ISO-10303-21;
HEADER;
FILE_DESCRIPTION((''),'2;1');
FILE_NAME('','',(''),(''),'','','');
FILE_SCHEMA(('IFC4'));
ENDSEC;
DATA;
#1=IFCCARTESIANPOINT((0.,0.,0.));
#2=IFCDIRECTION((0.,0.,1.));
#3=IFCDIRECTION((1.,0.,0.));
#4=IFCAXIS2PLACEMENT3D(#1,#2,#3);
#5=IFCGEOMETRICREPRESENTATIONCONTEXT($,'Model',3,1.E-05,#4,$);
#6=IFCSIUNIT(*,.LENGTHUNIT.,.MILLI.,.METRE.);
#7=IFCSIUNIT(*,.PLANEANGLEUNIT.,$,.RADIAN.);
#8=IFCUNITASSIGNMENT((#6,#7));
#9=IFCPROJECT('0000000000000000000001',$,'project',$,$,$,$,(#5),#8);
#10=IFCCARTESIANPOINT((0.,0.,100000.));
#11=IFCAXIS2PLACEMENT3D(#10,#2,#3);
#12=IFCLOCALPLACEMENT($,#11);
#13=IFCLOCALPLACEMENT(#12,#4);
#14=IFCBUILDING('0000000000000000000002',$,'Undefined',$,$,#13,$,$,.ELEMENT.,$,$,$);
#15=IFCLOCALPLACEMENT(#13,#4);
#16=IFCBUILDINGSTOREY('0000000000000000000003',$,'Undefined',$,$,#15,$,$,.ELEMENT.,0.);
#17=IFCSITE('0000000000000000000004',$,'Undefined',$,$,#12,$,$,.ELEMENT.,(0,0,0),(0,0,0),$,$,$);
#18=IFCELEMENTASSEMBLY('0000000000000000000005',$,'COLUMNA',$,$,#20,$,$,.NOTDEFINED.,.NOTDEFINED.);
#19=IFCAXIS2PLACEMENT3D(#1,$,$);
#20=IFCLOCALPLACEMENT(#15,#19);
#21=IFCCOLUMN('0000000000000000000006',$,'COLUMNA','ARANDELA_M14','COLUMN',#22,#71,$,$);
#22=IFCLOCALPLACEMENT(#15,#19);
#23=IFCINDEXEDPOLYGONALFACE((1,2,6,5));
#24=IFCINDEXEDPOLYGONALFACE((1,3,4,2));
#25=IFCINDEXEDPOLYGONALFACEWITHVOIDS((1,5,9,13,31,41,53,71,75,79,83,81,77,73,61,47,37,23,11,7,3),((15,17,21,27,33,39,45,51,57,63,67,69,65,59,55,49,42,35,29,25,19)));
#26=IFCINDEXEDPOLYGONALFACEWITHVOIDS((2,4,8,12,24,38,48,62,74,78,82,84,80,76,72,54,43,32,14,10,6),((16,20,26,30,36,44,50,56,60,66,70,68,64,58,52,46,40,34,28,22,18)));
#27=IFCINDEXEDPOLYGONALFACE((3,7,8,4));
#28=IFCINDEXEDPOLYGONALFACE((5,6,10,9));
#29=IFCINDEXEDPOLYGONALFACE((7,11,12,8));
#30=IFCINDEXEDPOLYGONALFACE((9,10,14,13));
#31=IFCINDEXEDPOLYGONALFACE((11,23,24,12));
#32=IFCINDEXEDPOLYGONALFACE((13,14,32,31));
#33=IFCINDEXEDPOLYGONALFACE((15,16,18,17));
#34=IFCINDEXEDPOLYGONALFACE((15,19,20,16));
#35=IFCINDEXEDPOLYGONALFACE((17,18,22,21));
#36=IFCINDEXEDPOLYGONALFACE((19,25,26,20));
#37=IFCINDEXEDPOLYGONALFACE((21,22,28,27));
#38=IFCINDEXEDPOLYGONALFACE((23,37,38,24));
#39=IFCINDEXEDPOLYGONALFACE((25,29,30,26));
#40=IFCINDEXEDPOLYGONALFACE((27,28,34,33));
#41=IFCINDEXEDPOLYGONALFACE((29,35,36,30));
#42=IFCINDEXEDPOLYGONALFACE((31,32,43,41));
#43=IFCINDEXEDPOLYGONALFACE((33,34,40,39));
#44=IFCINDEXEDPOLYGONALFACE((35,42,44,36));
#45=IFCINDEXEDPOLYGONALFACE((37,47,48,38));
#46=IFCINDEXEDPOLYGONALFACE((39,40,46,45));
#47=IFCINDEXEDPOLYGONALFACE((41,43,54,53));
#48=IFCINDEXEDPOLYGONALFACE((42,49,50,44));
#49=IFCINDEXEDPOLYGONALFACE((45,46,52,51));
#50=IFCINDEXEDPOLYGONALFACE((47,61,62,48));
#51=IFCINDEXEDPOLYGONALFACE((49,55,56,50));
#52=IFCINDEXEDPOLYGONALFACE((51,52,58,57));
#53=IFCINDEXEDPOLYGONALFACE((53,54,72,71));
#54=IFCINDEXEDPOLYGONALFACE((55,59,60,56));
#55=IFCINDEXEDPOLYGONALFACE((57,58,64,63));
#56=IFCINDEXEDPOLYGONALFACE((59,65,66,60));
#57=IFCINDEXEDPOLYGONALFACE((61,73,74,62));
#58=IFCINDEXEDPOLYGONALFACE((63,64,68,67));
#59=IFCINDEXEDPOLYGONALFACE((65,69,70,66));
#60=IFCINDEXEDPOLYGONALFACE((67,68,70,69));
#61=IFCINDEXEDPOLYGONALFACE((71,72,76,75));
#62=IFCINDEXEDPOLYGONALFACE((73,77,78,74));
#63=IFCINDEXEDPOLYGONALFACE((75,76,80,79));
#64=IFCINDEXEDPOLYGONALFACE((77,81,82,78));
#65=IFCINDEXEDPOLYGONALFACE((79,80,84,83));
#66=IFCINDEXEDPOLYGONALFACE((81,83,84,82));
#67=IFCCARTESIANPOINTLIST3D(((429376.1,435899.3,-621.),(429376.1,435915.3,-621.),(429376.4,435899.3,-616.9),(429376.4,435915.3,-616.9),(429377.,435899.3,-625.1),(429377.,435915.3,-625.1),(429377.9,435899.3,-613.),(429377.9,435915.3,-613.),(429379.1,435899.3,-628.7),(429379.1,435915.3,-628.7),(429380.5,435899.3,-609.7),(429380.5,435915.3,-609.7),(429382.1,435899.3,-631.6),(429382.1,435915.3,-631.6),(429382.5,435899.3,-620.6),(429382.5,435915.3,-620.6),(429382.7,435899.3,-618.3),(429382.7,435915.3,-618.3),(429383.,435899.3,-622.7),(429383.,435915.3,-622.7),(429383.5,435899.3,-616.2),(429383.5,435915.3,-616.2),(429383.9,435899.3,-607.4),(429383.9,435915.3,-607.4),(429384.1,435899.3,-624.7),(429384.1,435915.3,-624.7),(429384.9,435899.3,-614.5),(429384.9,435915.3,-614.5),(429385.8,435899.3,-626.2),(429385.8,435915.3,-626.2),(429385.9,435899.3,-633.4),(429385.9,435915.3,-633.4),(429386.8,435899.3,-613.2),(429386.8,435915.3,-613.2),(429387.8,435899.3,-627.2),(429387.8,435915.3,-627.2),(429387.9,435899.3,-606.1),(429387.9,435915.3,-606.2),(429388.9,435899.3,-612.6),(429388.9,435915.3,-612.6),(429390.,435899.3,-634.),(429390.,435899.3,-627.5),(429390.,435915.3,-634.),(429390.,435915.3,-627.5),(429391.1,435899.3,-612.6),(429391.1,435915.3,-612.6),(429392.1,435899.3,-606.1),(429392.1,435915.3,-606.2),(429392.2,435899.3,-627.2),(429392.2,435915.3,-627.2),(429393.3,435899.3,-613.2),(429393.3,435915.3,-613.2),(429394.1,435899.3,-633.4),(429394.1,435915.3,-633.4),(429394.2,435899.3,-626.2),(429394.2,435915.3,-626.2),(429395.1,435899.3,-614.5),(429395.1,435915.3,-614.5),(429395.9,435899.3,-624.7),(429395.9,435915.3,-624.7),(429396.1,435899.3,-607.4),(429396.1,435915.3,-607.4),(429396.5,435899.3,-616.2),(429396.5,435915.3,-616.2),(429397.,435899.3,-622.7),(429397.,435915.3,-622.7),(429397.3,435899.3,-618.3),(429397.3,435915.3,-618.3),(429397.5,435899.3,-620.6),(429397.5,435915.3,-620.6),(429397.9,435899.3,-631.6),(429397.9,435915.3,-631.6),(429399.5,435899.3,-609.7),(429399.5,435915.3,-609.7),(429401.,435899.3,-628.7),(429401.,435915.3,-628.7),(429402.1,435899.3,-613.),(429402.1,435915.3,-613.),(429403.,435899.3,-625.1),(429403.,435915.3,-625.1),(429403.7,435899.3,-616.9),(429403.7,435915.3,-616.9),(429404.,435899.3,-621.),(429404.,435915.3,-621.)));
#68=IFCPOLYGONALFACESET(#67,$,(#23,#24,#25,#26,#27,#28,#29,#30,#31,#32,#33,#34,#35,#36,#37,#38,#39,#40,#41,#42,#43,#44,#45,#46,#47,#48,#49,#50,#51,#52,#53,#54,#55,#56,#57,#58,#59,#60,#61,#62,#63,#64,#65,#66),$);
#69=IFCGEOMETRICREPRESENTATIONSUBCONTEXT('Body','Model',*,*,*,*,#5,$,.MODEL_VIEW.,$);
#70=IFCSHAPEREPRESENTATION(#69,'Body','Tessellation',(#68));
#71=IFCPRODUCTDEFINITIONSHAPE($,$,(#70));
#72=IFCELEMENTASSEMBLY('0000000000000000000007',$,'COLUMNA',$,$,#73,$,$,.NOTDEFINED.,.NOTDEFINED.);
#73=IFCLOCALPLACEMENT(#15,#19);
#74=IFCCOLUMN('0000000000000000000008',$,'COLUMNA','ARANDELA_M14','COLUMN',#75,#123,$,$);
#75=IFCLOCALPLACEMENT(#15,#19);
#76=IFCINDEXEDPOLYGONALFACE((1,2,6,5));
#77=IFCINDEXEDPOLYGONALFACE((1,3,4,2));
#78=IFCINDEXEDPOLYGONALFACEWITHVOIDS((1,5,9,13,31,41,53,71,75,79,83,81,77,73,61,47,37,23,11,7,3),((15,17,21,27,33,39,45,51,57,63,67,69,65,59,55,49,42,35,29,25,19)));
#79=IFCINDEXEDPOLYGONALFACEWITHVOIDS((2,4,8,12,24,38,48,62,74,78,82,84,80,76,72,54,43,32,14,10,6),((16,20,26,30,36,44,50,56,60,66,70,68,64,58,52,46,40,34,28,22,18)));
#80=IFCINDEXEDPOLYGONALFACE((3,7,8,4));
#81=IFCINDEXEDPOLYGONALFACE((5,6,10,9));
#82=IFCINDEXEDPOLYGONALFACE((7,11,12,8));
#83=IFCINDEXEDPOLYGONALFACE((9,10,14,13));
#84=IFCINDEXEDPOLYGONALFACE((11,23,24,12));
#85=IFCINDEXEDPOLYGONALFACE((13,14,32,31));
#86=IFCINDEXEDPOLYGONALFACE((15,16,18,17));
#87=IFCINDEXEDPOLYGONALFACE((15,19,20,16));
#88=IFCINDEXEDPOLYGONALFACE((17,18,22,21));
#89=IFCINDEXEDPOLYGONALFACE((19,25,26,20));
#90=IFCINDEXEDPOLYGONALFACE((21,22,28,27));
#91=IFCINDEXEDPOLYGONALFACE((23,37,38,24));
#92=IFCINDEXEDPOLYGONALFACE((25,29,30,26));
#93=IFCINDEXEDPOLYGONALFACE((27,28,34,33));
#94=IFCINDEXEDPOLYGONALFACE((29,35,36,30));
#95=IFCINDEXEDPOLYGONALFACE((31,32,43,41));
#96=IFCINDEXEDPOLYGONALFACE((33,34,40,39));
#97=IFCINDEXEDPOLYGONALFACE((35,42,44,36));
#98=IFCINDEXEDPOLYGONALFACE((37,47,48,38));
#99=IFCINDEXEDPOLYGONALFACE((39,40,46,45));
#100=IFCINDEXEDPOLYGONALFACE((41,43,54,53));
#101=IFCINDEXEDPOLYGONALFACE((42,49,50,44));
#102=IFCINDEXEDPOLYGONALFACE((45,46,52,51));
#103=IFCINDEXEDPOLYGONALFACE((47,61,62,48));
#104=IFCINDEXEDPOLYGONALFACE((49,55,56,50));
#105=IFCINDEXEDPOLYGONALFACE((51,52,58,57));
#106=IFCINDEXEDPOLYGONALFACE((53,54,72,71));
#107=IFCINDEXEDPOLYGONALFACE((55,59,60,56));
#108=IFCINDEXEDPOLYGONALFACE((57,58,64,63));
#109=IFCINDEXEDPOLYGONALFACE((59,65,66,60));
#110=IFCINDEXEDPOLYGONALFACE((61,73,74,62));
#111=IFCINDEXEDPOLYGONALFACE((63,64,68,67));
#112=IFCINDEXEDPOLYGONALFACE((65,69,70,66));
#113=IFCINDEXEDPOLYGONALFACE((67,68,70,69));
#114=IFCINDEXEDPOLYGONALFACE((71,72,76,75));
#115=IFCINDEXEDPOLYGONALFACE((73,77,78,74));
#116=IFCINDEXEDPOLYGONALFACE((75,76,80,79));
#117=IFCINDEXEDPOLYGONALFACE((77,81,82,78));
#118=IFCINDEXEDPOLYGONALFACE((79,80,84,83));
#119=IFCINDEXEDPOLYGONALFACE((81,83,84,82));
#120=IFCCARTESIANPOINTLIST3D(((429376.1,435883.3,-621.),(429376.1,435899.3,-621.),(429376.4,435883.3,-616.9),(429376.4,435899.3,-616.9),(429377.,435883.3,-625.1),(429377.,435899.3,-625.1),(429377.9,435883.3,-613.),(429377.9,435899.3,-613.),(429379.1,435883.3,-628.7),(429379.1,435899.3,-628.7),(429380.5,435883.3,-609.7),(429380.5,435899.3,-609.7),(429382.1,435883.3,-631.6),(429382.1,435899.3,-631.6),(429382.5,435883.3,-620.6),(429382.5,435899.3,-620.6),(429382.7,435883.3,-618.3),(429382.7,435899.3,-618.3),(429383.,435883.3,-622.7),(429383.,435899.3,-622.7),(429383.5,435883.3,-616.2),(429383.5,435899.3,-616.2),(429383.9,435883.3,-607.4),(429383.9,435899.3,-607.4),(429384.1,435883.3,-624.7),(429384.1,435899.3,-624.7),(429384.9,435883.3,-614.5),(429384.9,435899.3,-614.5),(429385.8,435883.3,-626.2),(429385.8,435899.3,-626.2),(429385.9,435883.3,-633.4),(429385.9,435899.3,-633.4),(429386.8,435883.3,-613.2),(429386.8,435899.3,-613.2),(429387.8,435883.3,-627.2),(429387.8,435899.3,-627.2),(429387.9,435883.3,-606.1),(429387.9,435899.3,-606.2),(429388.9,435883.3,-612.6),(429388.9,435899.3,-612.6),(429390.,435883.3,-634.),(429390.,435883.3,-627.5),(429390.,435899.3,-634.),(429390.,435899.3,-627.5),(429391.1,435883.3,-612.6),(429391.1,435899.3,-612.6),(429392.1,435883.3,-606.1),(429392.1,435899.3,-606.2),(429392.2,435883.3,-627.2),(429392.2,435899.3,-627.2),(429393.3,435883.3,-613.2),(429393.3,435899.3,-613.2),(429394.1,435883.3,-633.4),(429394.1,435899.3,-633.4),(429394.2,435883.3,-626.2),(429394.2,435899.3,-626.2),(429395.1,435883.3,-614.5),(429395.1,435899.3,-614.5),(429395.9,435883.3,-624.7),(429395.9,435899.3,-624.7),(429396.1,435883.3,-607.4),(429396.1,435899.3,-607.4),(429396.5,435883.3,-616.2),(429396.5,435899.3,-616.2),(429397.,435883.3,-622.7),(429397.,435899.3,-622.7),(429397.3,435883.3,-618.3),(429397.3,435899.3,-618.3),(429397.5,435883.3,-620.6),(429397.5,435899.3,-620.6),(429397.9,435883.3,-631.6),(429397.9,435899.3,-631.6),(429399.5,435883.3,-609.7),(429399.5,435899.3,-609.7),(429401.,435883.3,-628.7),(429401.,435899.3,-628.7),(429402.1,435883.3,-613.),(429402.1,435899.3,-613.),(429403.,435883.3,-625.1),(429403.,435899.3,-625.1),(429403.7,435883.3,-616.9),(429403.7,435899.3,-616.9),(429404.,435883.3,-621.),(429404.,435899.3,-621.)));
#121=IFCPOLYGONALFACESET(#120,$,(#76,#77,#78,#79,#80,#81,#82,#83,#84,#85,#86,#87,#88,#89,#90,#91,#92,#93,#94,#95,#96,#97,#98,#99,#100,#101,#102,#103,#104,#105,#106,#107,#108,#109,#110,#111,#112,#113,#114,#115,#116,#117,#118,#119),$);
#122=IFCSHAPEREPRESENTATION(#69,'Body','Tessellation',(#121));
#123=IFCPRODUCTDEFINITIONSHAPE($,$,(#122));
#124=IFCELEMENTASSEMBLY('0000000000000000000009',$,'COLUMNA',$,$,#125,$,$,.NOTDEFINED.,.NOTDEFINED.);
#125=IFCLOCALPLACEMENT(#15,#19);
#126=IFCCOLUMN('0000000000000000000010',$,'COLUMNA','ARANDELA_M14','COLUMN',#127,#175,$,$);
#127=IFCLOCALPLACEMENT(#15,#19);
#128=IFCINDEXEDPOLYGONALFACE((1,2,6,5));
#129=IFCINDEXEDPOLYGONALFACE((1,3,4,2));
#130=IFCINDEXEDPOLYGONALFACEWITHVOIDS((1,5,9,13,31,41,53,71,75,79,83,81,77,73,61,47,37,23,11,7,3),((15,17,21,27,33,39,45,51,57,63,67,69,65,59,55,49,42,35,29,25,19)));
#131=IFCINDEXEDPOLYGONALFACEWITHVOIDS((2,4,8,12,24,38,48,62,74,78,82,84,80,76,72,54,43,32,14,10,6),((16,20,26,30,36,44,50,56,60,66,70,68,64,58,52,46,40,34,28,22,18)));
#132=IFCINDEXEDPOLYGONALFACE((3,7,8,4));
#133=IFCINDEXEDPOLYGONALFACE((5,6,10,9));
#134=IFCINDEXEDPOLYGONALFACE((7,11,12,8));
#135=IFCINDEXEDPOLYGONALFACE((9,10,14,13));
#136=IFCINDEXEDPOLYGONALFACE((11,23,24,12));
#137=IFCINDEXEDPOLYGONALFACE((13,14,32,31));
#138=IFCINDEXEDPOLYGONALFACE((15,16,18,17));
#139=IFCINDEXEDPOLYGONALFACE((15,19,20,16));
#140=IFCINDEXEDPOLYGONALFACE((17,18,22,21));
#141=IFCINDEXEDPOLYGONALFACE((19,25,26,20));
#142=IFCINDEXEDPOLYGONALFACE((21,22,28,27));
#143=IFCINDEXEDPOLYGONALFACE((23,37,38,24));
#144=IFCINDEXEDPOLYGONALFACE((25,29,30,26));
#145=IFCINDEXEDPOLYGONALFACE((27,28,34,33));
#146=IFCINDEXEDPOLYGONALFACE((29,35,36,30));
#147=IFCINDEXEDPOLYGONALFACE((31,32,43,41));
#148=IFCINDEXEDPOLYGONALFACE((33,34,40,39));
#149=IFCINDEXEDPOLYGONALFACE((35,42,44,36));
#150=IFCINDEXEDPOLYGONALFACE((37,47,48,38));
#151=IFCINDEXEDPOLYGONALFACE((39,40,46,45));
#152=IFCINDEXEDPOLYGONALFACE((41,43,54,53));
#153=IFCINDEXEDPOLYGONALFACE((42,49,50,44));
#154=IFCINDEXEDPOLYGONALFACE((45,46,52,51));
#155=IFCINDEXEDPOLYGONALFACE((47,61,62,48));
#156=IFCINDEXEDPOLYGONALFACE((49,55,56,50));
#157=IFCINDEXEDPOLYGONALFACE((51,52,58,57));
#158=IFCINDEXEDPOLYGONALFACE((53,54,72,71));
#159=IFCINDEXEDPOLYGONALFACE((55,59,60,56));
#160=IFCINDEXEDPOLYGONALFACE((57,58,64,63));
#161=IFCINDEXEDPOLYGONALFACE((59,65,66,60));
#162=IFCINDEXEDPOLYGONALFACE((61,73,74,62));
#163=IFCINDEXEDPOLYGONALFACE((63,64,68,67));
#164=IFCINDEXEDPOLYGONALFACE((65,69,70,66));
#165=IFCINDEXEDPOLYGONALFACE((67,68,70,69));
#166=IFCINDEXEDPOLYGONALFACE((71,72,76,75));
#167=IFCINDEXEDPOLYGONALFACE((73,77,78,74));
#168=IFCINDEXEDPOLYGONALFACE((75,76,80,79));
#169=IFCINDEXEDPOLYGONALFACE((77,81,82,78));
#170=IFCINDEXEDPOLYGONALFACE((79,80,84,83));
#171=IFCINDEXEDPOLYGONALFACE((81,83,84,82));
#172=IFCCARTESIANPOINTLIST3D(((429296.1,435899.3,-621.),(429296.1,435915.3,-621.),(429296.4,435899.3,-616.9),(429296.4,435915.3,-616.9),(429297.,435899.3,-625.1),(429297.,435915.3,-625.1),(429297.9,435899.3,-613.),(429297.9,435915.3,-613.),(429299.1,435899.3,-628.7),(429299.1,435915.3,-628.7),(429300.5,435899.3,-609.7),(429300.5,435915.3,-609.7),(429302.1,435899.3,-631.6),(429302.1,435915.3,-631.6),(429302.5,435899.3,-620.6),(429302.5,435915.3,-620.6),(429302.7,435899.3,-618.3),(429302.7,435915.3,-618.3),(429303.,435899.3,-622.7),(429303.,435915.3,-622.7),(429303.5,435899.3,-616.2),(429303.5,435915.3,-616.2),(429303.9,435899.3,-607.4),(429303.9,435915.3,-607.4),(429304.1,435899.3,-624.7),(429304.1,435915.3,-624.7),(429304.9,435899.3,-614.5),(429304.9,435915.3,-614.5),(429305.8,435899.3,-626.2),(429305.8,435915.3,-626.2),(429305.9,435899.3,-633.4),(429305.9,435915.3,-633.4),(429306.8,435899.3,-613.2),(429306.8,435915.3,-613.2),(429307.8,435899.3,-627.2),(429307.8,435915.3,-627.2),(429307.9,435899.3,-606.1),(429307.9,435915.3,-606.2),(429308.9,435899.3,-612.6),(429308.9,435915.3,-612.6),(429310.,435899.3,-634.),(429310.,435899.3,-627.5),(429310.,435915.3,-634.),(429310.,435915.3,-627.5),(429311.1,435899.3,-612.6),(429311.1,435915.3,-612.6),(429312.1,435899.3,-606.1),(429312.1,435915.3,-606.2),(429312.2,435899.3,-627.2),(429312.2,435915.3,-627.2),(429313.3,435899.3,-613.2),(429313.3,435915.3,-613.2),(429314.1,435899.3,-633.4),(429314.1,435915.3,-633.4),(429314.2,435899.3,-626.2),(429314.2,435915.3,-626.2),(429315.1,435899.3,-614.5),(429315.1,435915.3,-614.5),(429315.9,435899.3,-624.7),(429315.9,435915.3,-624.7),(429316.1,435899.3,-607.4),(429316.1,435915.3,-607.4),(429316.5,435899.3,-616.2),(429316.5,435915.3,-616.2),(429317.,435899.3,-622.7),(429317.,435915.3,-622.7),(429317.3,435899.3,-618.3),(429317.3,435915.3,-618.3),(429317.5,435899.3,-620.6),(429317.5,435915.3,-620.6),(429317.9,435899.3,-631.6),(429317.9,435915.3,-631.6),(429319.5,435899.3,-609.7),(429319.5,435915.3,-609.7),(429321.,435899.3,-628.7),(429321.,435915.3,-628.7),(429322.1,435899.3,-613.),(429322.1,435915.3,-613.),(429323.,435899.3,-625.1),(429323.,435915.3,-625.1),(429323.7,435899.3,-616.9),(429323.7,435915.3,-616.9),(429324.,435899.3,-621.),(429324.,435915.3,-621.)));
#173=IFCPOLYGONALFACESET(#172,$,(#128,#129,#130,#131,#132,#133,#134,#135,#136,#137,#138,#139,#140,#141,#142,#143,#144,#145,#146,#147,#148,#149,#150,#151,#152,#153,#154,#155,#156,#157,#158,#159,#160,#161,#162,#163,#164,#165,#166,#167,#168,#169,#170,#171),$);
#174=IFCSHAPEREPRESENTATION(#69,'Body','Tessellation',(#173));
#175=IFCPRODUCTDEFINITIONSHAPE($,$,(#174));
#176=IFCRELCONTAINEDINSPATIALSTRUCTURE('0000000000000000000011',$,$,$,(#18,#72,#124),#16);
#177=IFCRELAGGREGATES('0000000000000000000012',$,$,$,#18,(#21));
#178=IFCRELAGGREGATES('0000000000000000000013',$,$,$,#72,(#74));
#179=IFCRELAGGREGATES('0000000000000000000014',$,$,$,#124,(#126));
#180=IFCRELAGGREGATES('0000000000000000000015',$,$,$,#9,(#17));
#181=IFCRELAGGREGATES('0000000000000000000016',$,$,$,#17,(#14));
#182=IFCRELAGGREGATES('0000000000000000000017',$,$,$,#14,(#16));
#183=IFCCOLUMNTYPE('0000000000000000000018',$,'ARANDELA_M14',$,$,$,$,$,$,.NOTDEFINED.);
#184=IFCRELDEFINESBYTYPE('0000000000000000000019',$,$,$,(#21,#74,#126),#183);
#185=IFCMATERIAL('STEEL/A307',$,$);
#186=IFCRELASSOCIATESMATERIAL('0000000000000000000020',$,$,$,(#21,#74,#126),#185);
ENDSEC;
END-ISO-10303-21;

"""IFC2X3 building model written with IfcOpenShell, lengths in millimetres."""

from ifc_helpers import new_model, si_unit, frame, origin_with_axes, origin_2d_with_axis, place, context, subcontext, project, spatial, hollow_circle, extrude, material, type_object, element, aggregate, save


model = new_model("IFC2X3")

# Units and contexts
model_context = context("Model", 3, precision=1e-05, world=origin_with_axes())
body_context = subcontext(model_context, "Body", "Model", "MODEL_VIEW")
ifc_project = project(units=[si_unit("LENGTHUNIT", "METRE", prefix="MILLI"), si_unit("PLANEANGLEUNIT", "RADIAN")], contexts=[model_context])

# Site, building, storey
site_placement = place(None, frame((0.0, 0.0, 100000.0), z_axis=(0.0, 0.0, 1.0), x_axis=(1.0, 0.0, 0.0)))
site = spatial("IfcSite", under=ifc_project, at=site_placement, Name="Undefined", CompositionType="ELEMENT", RefLatitude=(0, 0, 0), RefLongitude=(0, 0, 0))
building_placement = place(site_placement, origin_with_axes())
building = spatial("IfcBuilding", under=site, at=building_placement, Name="Undefined", CompositionType="ELEMENT")
storey_placement = place(building_placement, origin_with_axes())
storey = spatial("IfcBuildingStorey", under=building, at=storey_placement, Name="Undefined", CompositionType="ELEMENT", Elevation=0.0)

# Element assemblies, columns
ifc_material_1 = material(Name="STEEL/A307")
column_type = type_object("IfcColumnType", Name="ARANDELA_M14", PredefinedType="NOTDEFINED")
assembly_1_placement = place(storey_placement, origin_with_axes())
assembly_1 = element("IfcElementAssembly", 1, at=assembly_1_placement, inside=storey, Name="COLUMNA", AssemblyPlace="NOTDEFINED", PredefinedType="NOTDEFINED")
column_1_placement = place(assembly_1_placement, frame((429390.0, 435915.3, -620.0), z_axis=(0.0, -1.0, 0.000285), x_axis=(-1.0, 0.0, 0.0)))
column_1 = element("IfcColumn", 2, at=column_1_placement, type_object=column_type, material=ifc_material_1, Name="COLUMNA", Description="ARANDELA_M14", ObjectType="COLUMN", context=body_context, shape_type="SweptSolid", body=[
    extrude(hollow_circle(Radius=14.0, WallThickness=6.5, at=origin_2d_with_axis()), frame((0.0, 0.0, 16.0), z_axis=(0.0, 0.0, -1.0), x_axis=(0.0, 1.0, 0.0)), (0.0, 0.0, 1.0), 16.0),
])
aggregate(assembly_1, [column_1])
assembly_2_placement = place(storey_placement, origin_with_axes())
assembly_2 = element("IfcElementAssembly", 3, at=assembly_2_placement, inside=storey, Name="COLUMNA", AssemblyPlace="NOTDEFINED", PredefinedType="NOTDEFINED")
column_2_placement = place(assembly_2_placement, frame((429390.0, 435899.3, -620.0), z_axis=(0.0, -1.0, 0.000285), x_axis=(-1.0, 0.0, 0.0)))
column_2 = element("IfcColumn", 4, at=column_2_placement, type_object=column_type, material=ifc_material_1, Name="COLUMNA", Description="ARANDELA_M14", ObjectType="COLUMN", context=body_context, shape_type="SweptSolid", body=[
    extrude(hollow_circle(Radius=14.0, WallThickness=6.5, at=origin_2d_with_axis()), frame((0.0, 0.0, 16.0), z_axis=(0.0, 0.0, -1.0), x_axis=(0.0, 1.0, 0.0)), (0.0, 0.0, 1.0), 16.0),
])
aggregate(assembly_2, [column_2])
assembly_3_placement = place(storey_placement, origin_with_axes())
assembly_3 = element("IfcElementAssembly", 5, at=assembly_3_placement, inside=storey, Name="COLUMNA", AssemblyPlace="NOTDEFINED", PredefinedType="NOTDEFINED")
column_3_placement = place(assembly_3_placement, frame((429310.0, 435915.3, -620.0), z_axis=(0.0, -1.0, 0.000285), x_axis=(-1.0, 0.0, 0.0)))
column_3 = element("IfcColumn", 6, at=column_3_placement, type_object=column_type, material=ifc_material_1, Name="COLUMNA", Description="ARANDELA_M14", ObjectType="COLUMN", context=body_context, shape_type="SweptSolid", body=[
    extrude(hollow_circle(Radius=14.0, WallThickness=6.5, at=origin_2d_with_axis()), frame((0.0, 0.0, 16.0), z_axis=(0.0, 0.0, -1.0), x_axis=(0.0, 1.0, 0.0)), (0.0, 0.0, 1.0), 16.0),
])
aggregate(assembly_3, [column_3])

save(model, "model.ifc")
